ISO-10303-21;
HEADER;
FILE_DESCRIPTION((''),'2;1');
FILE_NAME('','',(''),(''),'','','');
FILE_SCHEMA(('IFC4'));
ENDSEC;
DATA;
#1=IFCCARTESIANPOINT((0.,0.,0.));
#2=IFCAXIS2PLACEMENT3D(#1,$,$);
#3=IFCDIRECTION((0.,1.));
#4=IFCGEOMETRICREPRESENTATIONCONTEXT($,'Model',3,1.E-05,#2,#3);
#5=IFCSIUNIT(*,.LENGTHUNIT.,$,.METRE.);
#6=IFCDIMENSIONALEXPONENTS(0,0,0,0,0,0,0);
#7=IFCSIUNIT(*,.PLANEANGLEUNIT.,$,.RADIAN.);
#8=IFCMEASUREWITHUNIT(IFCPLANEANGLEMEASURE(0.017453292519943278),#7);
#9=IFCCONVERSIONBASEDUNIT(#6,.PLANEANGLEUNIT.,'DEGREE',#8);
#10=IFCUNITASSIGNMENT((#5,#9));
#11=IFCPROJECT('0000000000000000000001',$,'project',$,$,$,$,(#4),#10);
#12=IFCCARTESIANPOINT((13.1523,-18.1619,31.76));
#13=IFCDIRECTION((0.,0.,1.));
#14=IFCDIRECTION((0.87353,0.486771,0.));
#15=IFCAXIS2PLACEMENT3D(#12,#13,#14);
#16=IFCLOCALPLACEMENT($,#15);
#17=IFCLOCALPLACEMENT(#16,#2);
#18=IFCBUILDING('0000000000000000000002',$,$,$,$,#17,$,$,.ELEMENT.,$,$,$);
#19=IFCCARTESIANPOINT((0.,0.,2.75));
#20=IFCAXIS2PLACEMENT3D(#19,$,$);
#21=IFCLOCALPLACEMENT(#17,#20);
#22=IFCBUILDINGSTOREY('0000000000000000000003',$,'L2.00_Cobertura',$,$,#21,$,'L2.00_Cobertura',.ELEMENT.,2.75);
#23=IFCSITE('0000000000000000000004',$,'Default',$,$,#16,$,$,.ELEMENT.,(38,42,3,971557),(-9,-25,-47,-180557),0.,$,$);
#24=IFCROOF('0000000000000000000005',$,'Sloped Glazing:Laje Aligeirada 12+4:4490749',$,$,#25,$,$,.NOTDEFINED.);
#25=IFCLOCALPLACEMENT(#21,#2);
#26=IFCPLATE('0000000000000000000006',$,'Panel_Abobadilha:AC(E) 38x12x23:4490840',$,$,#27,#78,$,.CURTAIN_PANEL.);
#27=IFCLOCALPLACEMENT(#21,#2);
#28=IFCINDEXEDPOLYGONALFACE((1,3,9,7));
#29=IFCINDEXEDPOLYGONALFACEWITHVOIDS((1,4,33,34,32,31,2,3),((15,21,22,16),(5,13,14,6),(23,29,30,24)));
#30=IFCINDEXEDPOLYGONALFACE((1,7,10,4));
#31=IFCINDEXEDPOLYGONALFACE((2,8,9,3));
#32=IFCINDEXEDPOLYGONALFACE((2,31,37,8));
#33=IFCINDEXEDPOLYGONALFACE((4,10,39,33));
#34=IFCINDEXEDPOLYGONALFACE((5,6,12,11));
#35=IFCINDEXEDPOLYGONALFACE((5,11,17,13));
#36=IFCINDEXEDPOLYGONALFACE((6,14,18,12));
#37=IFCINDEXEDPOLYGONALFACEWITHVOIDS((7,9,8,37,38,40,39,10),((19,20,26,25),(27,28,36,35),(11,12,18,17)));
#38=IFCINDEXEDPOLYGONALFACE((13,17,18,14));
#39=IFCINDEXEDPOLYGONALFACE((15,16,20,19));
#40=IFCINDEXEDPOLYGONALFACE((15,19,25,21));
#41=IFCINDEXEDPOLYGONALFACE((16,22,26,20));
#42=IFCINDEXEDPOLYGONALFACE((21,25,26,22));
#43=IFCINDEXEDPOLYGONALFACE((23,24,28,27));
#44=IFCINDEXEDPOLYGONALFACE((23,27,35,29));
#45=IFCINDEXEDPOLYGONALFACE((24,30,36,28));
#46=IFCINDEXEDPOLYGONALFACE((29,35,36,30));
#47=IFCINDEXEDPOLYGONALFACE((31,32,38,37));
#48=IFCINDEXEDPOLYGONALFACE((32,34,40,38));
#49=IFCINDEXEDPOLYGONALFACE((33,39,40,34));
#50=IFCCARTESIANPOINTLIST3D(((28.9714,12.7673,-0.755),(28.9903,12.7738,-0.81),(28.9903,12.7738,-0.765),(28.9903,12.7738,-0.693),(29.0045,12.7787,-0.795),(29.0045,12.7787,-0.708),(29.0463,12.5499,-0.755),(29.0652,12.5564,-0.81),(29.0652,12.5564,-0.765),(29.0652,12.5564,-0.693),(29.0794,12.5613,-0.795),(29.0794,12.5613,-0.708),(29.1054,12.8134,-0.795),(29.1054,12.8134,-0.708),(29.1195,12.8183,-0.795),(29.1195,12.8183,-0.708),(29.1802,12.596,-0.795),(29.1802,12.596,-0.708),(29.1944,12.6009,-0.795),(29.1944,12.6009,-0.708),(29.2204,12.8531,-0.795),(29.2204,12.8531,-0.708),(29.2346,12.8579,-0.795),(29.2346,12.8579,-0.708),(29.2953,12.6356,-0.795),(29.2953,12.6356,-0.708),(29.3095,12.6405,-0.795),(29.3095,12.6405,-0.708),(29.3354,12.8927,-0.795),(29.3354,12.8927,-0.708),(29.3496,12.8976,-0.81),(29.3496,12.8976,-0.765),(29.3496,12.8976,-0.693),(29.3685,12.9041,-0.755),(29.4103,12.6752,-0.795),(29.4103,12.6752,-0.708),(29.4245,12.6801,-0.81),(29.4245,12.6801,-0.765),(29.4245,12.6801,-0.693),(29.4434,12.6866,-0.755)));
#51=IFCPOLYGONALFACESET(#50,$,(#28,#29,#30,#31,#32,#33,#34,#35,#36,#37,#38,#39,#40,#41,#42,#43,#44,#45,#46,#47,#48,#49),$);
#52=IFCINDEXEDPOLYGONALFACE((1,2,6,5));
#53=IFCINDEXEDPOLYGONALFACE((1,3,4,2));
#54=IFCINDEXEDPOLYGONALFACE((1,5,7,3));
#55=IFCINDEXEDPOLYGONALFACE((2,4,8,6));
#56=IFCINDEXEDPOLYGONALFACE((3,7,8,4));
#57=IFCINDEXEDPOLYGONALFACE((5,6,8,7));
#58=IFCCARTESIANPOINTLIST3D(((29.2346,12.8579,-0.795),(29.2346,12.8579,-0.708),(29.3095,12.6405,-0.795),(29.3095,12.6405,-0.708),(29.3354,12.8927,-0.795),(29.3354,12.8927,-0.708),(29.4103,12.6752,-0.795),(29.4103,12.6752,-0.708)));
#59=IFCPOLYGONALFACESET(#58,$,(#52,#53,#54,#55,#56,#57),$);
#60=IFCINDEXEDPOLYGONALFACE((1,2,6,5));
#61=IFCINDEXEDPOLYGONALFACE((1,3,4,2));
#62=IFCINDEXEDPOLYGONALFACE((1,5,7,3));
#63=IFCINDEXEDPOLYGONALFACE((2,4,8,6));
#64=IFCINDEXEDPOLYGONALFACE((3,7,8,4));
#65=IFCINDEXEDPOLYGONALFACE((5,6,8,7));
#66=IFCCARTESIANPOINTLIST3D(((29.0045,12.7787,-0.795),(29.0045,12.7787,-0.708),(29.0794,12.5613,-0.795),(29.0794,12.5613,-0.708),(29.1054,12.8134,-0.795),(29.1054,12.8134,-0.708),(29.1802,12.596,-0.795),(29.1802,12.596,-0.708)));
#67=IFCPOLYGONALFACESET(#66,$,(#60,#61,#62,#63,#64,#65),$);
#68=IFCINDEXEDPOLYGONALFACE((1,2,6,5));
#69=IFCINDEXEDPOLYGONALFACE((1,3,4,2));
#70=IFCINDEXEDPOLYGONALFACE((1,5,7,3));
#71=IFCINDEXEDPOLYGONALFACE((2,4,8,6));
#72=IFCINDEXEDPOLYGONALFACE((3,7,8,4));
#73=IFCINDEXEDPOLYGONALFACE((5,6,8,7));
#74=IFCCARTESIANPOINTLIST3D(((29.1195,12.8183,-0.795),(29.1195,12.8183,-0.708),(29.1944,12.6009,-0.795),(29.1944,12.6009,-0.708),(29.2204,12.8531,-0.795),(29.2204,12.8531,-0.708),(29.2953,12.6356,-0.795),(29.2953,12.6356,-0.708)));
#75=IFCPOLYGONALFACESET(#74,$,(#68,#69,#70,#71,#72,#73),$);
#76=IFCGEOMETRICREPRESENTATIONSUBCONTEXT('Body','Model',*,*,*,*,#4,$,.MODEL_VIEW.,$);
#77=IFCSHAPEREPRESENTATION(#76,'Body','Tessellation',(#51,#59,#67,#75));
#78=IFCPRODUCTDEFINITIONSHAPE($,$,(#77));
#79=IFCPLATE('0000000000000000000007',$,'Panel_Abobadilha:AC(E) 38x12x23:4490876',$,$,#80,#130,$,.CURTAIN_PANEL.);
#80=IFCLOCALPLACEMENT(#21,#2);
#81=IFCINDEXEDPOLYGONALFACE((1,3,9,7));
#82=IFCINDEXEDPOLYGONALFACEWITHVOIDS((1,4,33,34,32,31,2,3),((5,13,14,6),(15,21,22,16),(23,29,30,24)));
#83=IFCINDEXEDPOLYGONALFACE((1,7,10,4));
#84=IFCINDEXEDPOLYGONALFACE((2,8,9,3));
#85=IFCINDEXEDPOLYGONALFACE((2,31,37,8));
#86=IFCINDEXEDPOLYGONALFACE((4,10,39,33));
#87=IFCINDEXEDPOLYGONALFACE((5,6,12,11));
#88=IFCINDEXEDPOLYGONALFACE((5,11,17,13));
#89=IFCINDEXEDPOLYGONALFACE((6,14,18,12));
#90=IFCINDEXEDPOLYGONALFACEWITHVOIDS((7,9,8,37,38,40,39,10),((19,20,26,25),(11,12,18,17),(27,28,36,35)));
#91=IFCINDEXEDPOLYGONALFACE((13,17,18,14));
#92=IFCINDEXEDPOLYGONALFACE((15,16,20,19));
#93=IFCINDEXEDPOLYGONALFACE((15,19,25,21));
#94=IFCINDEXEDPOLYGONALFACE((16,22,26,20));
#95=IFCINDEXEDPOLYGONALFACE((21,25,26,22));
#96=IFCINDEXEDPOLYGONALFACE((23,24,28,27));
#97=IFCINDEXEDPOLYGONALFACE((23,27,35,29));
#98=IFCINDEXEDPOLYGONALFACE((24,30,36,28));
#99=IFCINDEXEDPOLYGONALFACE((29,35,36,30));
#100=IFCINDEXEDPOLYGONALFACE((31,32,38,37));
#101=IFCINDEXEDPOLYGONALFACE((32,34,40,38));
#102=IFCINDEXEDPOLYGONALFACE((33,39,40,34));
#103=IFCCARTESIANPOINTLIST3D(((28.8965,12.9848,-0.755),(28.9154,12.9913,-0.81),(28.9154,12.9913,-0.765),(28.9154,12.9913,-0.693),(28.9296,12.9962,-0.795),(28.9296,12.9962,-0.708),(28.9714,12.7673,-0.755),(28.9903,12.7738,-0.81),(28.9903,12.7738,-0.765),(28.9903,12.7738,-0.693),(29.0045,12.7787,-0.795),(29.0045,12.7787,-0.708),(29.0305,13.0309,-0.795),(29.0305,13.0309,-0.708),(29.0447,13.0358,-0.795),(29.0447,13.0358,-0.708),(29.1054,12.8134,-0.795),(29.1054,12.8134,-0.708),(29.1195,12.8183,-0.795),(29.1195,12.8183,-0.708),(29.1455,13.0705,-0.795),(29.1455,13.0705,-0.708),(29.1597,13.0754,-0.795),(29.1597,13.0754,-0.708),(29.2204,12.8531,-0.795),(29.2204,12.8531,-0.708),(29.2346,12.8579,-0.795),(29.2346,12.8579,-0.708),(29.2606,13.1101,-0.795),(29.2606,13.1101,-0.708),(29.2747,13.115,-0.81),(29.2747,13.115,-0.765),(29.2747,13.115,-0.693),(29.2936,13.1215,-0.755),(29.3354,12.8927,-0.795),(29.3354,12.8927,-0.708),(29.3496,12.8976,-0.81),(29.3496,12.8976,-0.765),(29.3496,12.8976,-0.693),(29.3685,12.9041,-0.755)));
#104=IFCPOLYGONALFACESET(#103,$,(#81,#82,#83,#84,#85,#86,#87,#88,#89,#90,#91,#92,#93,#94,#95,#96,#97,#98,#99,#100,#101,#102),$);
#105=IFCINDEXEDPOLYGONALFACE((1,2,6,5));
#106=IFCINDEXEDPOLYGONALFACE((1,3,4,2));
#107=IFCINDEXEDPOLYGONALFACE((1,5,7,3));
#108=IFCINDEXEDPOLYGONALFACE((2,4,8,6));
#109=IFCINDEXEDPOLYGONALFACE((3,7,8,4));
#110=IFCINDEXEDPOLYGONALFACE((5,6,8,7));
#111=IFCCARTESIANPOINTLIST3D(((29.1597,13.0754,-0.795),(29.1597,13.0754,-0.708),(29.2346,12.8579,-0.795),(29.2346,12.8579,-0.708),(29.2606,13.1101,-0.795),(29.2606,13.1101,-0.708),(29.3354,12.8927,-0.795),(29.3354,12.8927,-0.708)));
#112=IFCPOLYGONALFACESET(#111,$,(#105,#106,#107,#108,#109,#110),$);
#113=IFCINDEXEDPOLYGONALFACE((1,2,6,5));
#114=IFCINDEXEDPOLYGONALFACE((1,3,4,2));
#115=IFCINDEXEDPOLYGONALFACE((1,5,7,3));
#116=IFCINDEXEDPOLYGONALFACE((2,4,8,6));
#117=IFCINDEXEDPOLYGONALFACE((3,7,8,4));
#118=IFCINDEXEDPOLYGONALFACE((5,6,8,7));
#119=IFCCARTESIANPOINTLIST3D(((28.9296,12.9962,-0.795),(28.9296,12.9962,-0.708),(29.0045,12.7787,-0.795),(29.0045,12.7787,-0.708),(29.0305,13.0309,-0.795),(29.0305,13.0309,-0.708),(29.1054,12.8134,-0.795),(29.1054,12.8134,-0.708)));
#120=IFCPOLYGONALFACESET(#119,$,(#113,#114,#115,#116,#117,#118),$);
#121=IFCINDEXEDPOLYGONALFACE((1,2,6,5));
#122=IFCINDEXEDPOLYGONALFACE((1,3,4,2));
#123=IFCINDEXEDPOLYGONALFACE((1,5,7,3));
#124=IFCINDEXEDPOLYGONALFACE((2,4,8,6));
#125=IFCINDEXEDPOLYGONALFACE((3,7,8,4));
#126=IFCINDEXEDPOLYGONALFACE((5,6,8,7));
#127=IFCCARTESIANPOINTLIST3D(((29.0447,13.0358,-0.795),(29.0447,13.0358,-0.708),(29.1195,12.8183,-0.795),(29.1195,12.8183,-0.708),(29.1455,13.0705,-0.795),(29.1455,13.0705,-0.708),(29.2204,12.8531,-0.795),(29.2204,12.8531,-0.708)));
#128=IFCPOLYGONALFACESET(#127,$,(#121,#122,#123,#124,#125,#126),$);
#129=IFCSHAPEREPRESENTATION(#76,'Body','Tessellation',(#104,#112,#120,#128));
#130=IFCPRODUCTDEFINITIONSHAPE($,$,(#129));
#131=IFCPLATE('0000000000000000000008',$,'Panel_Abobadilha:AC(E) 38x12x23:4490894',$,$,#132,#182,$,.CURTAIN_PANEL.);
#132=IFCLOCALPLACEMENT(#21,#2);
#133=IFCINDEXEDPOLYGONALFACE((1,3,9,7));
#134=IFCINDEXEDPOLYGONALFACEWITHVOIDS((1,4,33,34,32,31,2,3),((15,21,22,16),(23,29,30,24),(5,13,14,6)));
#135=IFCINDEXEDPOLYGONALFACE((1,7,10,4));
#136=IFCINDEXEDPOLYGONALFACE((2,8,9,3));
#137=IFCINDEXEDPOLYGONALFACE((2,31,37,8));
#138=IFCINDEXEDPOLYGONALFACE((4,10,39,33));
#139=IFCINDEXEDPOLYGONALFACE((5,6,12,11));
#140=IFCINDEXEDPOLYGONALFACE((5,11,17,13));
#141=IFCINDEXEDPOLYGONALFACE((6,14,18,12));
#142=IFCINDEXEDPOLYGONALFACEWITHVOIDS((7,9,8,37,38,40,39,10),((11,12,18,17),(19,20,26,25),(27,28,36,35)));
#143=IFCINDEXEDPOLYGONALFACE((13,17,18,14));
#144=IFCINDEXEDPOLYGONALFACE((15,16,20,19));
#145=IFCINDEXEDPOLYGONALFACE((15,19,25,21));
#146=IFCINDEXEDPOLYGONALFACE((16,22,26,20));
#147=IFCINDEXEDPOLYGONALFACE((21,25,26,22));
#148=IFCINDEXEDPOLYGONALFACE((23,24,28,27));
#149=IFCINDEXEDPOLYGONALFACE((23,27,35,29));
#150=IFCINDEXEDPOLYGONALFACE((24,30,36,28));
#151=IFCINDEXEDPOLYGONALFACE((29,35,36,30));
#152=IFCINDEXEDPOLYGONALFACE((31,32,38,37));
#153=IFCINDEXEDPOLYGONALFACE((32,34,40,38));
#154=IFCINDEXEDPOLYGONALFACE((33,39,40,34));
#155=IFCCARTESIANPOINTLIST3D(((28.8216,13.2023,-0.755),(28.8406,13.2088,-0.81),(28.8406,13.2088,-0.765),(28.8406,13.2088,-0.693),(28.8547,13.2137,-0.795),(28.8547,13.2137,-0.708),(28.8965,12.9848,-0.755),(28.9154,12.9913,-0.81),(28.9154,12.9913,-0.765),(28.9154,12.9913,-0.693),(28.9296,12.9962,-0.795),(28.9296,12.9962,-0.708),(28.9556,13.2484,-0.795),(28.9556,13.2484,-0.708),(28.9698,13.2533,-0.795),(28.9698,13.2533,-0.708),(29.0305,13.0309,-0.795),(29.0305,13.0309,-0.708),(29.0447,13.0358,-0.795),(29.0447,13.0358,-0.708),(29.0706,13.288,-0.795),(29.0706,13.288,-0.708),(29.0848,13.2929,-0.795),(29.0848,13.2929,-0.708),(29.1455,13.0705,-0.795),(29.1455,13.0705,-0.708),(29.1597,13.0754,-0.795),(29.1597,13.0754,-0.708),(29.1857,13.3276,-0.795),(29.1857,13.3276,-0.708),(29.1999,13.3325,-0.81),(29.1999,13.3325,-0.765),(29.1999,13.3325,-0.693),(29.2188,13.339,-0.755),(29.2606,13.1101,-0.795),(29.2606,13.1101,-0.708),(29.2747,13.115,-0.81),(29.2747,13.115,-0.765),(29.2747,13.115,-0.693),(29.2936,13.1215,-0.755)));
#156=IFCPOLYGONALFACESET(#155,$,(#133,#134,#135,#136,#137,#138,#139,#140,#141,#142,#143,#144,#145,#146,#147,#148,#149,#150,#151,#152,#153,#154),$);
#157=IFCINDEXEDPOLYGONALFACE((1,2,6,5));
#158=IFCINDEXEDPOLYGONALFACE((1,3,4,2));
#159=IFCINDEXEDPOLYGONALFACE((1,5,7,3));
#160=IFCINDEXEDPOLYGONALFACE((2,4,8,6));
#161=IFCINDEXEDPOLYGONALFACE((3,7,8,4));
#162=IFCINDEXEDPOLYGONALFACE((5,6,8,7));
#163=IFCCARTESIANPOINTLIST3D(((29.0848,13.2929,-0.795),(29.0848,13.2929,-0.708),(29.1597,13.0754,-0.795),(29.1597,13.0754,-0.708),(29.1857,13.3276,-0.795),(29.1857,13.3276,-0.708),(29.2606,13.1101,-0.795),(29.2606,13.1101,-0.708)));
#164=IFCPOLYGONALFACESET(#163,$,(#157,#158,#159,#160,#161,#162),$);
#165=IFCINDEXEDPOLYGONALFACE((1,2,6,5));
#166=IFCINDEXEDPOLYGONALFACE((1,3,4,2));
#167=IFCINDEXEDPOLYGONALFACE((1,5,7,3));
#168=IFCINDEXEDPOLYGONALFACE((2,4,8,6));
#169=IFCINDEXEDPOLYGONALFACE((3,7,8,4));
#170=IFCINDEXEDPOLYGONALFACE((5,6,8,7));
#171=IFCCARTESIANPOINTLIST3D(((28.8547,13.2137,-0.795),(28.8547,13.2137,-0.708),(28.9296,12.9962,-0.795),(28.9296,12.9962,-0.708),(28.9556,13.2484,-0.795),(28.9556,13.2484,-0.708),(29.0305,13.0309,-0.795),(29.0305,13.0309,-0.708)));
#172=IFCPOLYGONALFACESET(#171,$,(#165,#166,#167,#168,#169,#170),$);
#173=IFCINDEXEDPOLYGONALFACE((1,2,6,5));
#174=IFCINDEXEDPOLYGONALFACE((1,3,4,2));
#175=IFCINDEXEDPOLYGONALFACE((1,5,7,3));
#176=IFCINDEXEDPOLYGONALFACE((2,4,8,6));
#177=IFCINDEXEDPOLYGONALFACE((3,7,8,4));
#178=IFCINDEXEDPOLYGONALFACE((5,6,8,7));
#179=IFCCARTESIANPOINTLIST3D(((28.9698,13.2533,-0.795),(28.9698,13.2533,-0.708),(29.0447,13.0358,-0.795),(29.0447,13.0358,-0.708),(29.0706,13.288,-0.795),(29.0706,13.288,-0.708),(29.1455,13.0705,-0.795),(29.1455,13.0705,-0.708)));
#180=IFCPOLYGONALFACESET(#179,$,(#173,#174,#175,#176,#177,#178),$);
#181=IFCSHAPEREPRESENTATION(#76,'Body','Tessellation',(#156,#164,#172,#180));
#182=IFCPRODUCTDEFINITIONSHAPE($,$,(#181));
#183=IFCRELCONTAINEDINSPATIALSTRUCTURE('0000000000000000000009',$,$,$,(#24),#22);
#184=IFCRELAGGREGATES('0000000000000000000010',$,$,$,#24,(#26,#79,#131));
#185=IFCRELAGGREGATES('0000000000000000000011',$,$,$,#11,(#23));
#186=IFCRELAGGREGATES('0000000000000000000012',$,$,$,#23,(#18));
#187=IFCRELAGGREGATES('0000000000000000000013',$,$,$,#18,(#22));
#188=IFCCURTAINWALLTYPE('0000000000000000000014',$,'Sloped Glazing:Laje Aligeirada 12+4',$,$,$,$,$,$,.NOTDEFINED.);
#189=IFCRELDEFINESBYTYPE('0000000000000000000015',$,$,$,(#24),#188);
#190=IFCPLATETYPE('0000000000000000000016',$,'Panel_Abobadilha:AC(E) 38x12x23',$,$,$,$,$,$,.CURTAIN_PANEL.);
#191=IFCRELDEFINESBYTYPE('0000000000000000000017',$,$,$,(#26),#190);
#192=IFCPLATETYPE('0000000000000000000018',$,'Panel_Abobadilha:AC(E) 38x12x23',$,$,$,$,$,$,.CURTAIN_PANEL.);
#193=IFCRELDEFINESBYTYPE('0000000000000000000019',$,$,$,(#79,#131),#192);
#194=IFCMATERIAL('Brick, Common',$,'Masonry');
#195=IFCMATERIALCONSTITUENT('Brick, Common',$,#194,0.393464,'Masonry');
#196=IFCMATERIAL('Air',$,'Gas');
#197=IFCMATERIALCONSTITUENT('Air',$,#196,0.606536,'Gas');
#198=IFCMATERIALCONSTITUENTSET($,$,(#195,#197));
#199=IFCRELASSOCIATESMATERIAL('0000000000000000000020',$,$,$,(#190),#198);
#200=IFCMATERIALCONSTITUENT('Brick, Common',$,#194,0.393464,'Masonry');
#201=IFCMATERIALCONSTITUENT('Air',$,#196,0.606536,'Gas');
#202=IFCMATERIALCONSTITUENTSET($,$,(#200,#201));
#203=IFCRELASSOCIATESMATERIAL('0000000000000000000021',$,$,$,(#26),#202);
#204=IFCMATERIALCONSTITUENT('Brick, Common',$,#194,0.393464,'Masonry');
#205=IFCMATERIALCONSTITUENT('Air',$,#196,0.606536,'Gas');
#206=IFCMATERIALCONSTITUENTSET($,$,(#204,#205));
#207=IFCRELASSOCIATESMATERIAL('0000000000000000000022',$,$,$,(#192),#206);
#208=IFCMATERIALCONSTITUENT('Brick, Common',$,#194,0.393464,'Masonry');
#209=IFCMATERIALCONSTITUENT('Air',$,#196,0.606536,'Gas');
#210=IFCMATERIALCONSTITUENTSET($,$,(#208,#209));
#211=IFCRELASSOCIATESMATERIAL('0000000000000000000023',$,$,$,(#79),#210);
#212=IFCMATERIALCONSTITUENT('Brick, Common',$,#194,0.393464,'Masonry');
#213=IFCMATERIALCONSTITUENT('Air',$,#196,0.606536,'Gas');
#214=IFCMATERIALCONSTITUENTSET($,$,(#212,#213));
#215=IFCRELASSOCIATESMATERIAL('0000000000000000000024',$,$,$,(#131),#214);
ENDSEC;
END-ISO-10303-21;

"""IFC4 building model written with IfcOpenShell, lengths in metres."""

from ifc_helpers import new_model, entity, si_unit, converted_unit, direction, frame, origin, place, context, subcontext, project, spatial, indexed_curve, outline, extrude, source, transform, mapped, material, constituent, constituent_set, type_object, type_shapes, element, aggregate, save


model = new_model("IFC4")

# Units and contexts
model_context = context("Model", 3, precision=1e-05, world=origin(), true_north=direction((0.0, 1.0)))
body_context = subcontext(model_context, "Body", "Model", "MODEL_VIEW")
ifc_project = project(units=[si_unit("LENGTHUNIT", "METRE"), converted_unit("PLANEANGLEUNIT", "DEGREE", entity("IfcPlaneAngleMeasure", 0.017453292519943278), si_unit("PLANEANGLEUNIT", "RADIAN"), dimensions=[0, 0, 0, 0, 0, 0, 0])], contexts=[model_context])

# Site, building, storey
site_placement = place(None, frame((13.1523, -18.1619, 31.76), z_axis=(0.0, 0.0, 1.0), x_axis=(0.87353, 0.486771, 0.0)))
site = spatial("IfcSite", under=ifc_project, at=site_placement, Name="Default", CompositionType="ELEMENT", RefLatitude=(38, 42, 3, 971557), RefLongitude=(-9, -25, -47, -180557), RefElevation=0.0)
building_placement = place(site_placement, origin())
building = spatial("IfcBuilding", under=site, at=building_placement, CompositionType="ELEMENT")
storey_placement = place(building_placement, frame((0.0, 0.0, 2.75)))
storey = spatial("IfcBuildingStorey", under=building, at=storey_placement, Name="L2.00_Cobertura", LongName="L2.00_Cobertura", CompositionType="ELEMENT", Elevation=2.75)

# Roof, plates
curtain_wall_type = type_object("IfcCurtainWallType", Name="Sloped Glazing:Laje Aligeirada 12+4", PredefinedType="NOTDEFINED")
roof_placement = place(storey_placement, frame((0.0, 0.0, -2.75)))
roof = element("IfcRoof", 1, at=roof_placement, inside=storey, type_object=curtain_wall_type, Name="Sloped Glazing:Laje Aligeirada 12+4:4490749", PredefinedType="NOTDEFINED")
ifc_material_1 = material(Name="Brick, Common", Category="Masonry")
ifc_constituent_1 = constituent(ifc_material_1, Name="Brick, Common", Category="Masonry", fraction=0.393464)
ifc_material_2 = material(Name="Air", Category="Gas")
ifc_constituent_2 = constituent(ifc_material_2, Name="Air", Category="Gas", fraction=0.606536)
ifc_constituent_set_1 = constituent_set(constituents=[ifc_constituent_1, ifc_constituent_2])
ifc_constituent_3 = constituent(ifc_material_1, Name="Brick, Common", Category="Masonry", fraction=0.393464)
ifc_constituent_4 = constituent(ifc_material_2, Name="Air", Category="Gas", fraction=0.606536)
ifc_constituent_set_2 = constituent_set(constituents=[ifc_constituent_3, ifc_constituent_4])
plate_type_1 = type_object("IfcPlateType", Name="Panel_Abobadilha:AC(E) 38x12x23", PredefinedType="CURTAIN_PANEL", material=ifc_constituent_set_2)
shared_shape_1 = source(origin(), body_context, "Body", "SweptSolid", [
    extrude(outline(indexed_curve([(-0.19, -0.0543), (0.19, -0.0543), (0.19, -0.0093), (0.21, 0.0007), (0.19, 0.0628), (-0.19, 0.0628), (-0.21, 0.0007), (-0.19, -0.0093), (-0.19, -0.0543)], self_intersect=False), holes=[indexed_curve([(-0.0683, 0.0477), (-0.0683, -0.0393), (-0.175, -0.0393), (-0.175, 0.0477), (-0.0683, 0.0477)], self_intersect=False), indexed_curve([(0.0533, 0.0477), (0.0533, -0.0393), (-0.0533, -0.0393), (-0.0533, 0.0477), (0.0533, 0.0477)], self_intersect=False), indexed_curve([(0.175, 0.0477), (0.175, -0.0393), (0.0683, -0.0393), (0.0683, 0.0477), (0.175, 0.0477)], self_intersect=False)]), frame((0.0, 0.0543, 0.0)), (0.0, 0.0, 1.0), 0.23),
    extrude(outline(indexed_curve([(-0.0533, -0.0435), (0.0533, -0.0435), (0.0533, 0.0435), (-0.0533, 0.0435), (-0.0533, -0.0435)], self_intersect=False)), frame((0.1217, 0.0585, 0.0), z_axis=(0.0, 0.0, 1.0), x_axis=(-1.0, 0.0, 0.0)), (0.0, 0.0, 1.0), 0.23),
    extrude(outline(indexed_curve([(-0.0533, -0.0435), (0.0533, -0.0435), (0.0533, 0.0435), (-0.0533, 0.0435), (-0.0533, -0.0435)], self_intersect=False)), frame((-0.1217, 0.0585, 0.0), z_axis=(0.0, 0.0, 1.0), x_axis=(-1.0, 0.0, 0.0)), (0.0, 0.0, 1.0), 0.23),
    extrude(outline(indexed_curve([(-0.0533, -0.0435), (0.0533, -0.0435), (0.0533, 0.0435), (-0.0533, 0.0435), (-0.0533, -0.0435)], self_intersect=False)), frame((0.0, 0.0585, 0.0), z_axis=(0.0, 0.0, 1.0), x_axis=(-1.0, 0.0, 0.0)), (0.0, 0.0, 1.0), 0.23),
])
type_shapes(plate_type_1, [shared_shape_1])
plate_1_placement = place(roof_placement, frame((29.17, 12.8357, 1.94), z_axis=(0.325568, -0.945519, 0.0), x_axis=(0.945519, 0.325568, 0.0)))
plate_1 = element("IfcPlate", 2, at=plate_1_placement, type_object=plate_type_1, material=ifc_constituent_set_1, Name="Panel_Abobadilha:AC(E) 38x12x23:4490840", PredefinedType="CURTAIN_PANEL", context=body_context, shape_type="MappedRepresentation", body=[
    mapped(shared_shape_1, transform((0.0, 0.0, 0.0), scale=1.0)),
])
ifc_constituent_5 = constituent(ifc_material_1, Name="Brick, Common", Category="Masonry", fraction=0.393464)
ifc_constituent_6 = constituent(ifc_material_2, Name="Air", Category="Gas", fraction=0.606536)
ifc_constituent_set_3 = constituent_set(constituents=[ifc_constituent_5, ifc_constituent_6])
ifc_constituent_7 = constituent(ifc_material_1, Name="Brick, Common", Category="Masonry", fraction=0.393464)
ifc_constituent_8 = constituent(ifc_material_2, Name="Air", Category="Gas", fraction=0.606536)
ifc_constituent_set_4 = constituent_set(constituents=[ifc_constituent_7, ifc_constituent_8])
plate_type_2 = type_object("IfcPlateType", Name="Panel_Abobadilha:AC(E) 38x12x23", PredefinedType="CURTAIN_PANEL", material=ifc_constituent_set_4)
shared_shape_2 = source(origin(), body_context, "Body", "SweptSolid", [
    extrude(outline(indexed_curve([(-0.19, -0.0543), (0.19, -0.0543), (0.19, -0.0093), (0.21, 0.0007), (0.19, 0.0628), (-0.19, 0.0628), (-0.21, 0.0007), (-0.19, -0.0093), (-0.19, -0.0543)], self_intersect=False), holes=[indexed_curve([(-0.0683, 0.0477), (-0.0683, -0.0393), (-0.175, -0.0393), (-0.175, 0.0477), (-0.0683, 0.0477)], self_intersect=False), indexed_curve([(0.0533, 0.0477), (0.0533, -0.0393), (-0.0533, -0.0393), (-0.0533, 0.0477), (0.0533, 0.0477)], self_intersect=False), indexed_curve([(0.175, 0.0477), (0.175, -0.0393), (0.0683, -0.0393), (0.0683, 0.0477), (0.175, 0.0477)], self_intersect=False)]), frame((0.0, 0.0543, 0.0)), (0.0, 0.0, 1.0), 0.23),
    extrude(outline(indexed_curve([(-0.0533, -0.0435), (0.0533, -0.0435), (0.0533, 0.0435), (-0.0533, 0.0435), (-0.0533, -0.0435)], self_intersect=False)), frame((0.1217, 0.0585, 0.0), z_axis=(0.0, 0.0, 1.0), x_axis=(-1.0, 0.0, 0.0)), (0.0, 0.0, 1.0), 0.23),
    extrude(outline(indexed_curve([(-0.0533, -0.0435), (0.0533, -0.0435), (0.0533, 0.0435), (-0.0533, 0.0435), (-0.0533, -0.0435)], self_intersect=False)), frame((-0.1217, 0.0585, 0.0), z_axis=(0.0, 0.0, 1.0), x_axis=(-1.0, 0.0, 0.0)), (0.0, 0.0, 1.0), 0.23),
    extrude(outline(indexed_curve([(-0.0533, -0.0435), (0.0533, -0.0435), (0.0533, 0.0435), (-0.0533, 0.0435), (-0.0533, -0.0435)], self_intersect=False)), frame((0.0, 0.0585, 0.0), z_axis=(0.0, 0.0, 1.0), x_axis=(-1.0, 0.0, 0.0)), (0.0, 0.0, 1.0), 0.23),
])
type_shapes(plate_type_2, [shared_shape_2])
plate_2_placement = place(roof_placement, frame((29.0951, 13.0532, 1.94), z_axis=(0.325568, -0.945519, 0.0), x_axis=(0.945519, 0.325568, 0.0)))
plate_2 = element("IfcPlate", 3, at=plate_2_placement, type_object=plate_type_2, material=ifc_constituent_set_3, Name="Panel_Abobadilha:AC(E) 38x12x23:4490876", PredefinedType="CURTAIN_PANEL", context=body_context, shape_type="MappedRepresentation", body=[
    mapped(shared_shape_2, transform((0.0, 0.0, 0.0), scale=1.0)),
])
ifc_constituent_9 = constituent(ifc_material_1, Name="Brick, Common", Category="Masonry", fraction=0.393464)
ifc_constituent_10 = constituent(ifc_material_2, Name="Air", Category="Gas", fraction=0.606536)
ifc_constituent_set_5 = constituent_set(constituents=[ifc_constituent_9, ifc_constituent_10])
plate_3_placement = place(roof_placement, frame((29.0202, 13.2706, 1.94), z_axis=(0.325568, -0.945519, 0.0), x_axis=(0.945519, 0.325568, 0.0)))
plate_3 = element("IfcPlate", 4, at=plate_3_placement, type_object=plate_type_2, material=ifc_constituent_set_5, Name="Panel_Abobadilha:AC(E) 38x12x23:4490894", PredefinedType="CURTAIN_PANEL", context=body_context, shape_type="MappedRepresentation", body=[
    mapped(shared_shape_2, transform((0.0, 0.0, 0.0), scale=1.0)),
])
aggregate(roof, [plate_1, plate_2, plate_3])

save(model, "model.ifc")
